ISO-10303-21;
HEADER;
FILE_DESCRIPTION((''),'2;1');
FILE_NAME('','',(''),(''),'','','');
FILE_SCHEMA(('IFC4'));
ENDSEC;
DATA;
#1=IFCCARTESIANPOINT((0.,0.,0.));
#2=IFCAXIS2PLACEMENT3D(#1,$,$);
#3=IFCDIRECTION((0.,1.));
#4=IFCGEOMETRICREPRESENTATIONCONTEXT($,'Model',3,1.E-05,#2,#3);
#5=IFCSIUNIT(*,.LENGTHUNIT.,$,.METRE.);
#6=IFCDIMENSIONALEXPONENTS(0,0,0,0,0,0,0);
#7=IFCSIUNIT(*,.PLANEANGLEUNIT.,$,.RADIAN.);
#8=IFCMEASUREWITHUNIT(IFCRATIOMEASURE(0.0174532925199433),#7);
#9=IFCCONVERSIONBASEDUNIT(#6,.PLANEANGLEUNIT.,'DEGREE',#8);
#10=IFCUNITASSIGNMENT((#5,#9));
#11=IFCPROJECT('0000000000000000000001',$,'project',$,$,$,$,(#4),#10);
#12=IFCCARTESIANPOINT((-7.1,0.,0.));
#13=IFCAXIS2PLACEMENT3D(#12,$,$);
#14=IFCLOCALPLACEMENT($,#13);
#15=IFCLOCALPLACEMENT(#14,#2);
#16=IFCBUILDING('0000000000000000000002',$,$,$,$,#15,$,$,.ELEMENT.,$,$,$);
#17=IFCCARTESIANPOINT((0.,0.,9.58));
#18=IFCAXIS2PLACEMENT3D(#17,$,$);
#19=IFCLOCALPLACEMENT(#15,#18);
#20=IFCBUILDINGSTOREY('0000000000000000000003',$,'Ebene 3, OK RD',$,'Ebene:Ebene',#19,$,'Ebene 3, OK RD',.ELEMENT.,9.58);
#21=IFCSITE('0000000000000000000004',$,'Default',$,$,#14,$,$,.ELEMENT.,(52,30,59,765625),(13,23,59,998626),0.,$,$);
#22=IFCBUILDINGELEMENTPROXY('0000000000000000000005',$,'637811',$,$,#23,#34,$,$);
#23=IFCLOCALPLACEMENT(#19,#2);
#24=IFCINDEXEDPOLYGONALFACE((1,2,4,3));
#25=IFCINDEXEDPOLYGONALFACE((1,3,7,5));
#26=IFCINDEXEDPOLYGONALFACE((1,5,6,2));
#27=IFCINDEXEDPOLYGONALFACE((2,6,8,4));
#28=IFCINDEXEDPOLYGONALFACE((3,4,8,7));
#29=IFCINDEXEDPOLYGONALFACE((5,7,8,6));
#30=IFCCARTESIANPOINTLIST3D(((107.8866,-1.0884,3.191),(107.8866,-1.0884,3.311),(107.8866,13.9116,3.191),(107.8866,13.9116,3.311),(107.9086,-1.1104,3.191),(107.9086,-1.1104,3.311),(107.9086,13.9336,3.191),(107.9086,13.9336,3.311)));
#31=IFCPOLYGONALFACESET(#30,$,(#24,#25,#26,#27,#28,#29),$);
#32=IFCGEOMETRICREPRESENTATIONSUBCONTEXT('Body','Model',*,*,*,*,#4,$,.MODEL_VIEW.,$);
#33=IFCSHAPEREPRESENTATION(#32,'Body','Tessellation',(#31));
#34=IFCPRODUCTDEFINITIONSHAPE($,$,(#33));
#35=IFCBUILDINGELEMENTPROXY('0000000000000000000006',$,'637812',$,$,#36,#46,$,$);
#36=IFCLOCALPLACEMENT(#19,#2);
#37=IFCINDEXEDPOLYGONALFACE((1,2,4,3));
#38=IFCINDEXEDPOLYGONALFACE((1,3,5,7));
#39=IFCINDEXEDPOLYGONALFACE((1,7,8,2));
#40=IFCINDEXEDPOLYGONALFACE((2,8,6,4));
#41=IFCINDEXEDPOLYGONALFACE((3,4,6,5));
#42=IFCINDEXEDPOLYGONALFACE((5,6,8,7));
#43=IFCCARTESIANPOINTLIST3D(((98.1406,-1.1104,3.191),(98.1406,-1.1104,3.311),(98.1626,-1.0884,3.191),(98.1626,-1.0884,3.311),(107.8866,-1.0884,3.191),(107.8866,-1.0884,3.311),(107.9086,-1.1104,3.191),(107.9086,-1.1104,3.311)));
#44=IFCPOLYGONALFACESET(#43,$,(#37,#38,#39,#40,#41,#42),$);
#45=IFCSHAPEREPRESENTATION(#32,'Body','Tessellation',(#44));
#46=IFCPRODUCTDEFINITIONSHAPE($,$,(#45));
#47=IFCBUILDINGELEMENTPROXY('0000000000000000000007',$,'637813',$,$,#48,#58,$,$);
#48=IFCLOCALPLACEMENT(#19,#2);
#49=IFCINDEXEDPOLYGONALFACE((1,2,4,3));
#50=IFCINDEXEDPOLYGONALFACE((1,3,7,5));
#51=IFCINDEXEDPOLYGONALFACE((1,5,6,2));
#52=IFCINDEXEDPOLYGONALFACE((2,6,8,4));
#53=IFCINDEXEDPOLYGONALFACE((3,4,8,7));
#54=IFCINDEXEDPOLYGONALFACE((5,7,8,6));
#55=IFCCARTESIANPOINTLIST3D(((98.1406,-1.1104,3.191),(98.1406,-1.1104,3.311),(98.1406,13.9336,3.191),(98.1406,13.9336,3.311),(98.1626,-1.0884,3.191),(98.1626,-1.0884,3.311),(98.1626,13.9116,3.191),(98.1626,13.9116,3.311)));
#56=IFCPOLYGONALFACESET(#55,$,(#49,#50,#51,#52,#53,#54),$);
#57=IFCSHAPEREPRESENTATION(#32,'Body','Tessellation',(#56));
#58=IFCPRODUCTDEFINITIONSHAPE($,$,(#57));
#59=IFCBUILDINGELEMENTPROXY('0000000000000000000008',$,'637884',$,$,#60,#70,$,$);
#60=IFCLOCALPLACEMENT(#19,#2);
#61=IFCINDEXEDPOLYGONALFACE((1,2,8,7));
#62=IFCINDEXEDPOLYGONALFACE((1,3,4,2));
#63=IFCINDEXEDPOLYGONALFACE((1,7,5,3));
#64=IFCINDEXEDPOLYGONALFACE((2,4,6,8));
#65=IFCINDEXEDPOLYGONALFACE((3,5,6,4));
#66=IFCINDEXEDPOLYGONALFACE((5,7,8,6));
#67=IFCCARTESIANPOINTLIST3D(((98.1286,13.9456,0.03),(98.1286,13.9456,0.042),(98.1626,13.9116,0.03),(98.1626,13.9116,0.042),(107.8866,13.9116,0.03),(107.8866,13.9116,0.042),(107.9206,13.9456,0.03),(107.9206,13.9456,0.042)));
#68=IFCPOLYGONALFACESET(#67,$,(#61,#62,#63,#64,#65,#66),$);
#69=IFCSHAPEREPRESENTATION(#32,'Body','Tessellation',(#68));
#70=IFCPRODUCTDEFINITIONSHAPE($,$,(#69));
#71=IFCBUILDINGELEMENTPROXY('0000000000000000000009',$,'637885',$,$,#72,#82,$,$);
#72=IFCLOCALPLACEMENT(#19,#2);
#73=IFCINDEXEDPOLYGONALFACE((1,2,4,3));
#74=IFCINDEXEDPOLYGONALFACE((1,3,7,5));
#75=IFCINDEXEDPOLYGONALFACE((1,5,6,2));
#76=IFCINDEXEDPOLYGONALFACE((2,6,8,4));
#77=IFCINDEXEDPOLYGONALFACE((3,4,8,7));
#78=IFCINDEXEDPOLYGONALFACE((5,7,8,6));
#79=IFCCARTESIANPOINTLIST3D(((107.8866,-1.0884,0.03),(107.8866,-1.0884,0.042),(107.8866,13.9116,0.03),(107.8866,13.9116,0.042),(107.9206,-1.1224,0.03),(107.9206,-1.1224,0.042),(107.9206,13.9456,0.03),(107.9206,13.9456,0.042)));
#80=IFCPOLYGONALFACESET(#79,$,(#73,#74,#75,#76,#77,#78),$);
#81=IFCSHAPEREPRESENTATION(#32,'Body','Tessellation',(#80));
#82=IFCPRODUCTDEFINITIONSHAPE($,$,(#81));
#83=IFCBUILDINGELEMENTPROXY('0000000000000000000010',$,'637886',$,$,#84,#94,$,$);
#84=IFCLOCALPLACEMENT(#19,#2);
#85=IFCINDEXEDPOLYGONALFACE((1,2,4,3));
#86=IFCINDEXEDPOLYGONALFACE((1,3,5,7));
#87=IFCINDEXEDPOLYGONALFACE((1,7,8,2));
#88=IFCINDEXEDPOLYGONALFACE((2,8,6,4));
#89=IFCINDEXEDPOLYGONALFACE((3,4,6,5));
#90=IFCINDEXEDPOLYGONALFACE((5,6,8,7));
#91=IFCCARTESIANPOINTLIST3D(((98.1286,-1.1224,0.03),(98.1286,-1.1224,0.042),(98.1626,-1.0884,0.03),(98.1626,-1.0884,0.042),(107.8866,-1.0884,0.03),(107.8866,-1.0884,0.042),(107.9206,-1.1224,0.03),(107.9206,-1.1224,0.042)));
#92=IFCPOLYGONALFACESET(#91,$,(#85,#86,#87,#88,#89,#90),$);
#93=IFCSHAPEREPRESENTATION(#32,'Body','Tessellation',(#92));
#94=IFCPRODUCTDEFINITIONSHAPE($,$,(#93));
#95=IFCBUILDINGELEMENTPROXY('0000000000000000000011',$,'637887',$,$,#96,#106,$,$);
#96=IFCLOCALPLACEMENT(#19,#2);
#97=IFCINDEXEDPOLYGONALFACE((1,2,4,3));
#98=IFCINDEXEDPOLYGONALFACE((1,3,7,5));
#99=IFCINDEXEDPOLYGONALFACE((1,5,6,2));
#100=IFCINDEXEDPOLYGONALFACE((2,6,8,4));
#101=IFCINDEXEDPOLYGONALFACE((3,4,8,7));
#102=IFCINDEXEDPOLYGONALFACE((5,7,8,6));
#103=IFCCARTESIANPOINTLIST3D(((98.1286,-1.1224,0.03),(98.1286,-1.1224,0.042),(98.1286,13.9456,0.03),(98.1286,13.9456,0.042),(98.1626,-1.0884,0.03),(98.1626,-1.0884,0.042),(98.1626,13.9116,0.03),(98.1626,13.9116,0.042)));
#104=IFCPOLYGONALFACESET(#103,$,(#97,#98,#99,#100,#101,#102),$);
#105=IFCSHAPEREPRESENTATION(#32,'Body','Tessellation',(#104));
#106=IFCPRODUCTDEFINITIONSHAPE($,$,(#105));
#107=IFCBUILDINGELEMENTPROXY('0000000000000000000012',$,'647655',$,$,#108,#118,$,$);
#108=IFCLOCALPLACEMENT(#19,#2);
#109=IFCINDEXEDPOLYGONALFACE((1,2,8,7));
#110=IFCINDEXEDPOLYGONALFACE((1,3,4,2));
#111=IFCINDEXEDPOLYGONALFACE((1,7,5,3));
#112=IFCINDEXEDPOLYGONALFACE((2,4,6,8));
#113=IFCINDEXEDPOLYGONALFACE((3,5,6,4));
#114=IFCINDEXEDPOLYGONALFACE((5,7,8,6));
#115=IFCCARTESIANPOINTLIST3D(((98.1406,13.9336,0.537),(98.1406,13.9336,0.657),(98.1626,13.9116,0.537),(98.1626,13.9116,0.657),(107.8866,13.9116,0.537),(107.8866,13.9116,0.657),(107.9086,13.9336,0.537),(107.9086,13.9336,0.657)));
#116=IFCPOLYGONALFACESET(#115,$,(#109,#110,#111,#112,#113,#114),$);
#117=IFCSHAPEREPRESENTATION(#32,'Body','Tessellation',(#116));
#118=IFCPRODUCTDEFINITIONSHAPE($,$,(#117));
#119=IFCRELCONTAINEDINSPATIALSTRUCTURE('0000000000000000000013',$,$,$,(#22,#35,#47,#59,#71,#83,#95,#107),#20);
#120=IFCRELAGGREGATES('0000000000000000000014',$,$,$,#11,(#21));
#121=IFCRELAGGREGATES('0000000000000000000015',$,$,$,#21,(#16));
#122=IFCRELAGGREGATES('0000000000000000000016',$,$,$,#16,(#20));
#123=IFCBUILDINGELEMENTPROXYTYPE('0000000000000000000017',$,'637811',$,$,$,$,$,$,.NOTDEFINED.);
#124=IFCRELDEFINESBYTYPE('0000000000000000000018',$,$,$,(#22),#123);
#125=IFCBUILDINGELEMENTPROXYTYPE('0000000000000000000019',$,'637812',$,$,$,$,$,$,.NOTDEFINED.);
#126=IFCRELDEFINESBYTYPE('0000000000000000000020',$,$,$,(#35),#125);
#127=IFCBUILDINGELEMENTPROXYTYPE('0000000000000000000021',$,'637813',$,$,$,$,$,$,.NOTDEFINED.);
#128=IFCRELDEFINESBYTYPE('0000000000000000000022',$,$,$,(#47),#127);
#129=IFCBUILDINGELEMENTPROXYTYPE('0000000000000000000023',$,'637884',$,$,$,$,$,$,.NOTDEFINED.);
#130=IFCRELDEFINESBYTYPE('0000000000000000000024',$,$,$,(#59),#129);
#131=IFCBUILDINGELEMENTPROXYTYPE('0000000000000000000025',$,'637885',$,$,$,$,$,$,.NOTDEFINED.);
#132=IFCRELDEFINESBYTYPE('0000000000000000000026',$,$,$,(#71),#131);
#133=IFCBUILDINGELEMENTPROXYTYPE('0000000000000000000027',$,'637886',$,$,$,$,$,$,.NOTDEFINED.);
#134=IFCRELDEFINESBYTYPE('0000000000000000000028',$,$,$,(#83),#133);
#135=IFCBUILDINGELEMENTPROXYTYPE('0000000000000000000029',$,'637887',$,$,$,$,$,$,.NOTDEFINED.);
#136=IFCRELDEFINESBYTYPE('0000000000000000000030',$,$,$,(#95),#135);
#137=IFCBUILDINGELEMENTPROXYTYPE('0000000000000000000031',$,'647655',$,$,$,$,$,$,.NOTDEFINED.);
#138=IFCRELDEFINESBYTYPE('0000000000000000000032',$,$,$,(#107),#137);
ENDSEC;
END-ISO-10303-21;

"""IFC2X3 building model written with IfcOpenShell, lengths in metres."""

from ifc_helpers import new_model, entity, si_unit, converted_unit, direction, frame, origin, place, context, subcontext, project, spatial, polyline, outline, extrude, type_object, element, save


model = new_model("IFC2X3")

# Units and contexts
model_context = context("Model", 3, precision=1e-05, world=origin(), true_north=direction((0.0, 1.0)))
body_context = subcontext(model_context, "Body", "Model", "MODEL_VIEW")
ifc_project = project(units=[si_unit("LENGTHUNIT", "METRE"), converted_unit("PLANEANGLEUNIT", "DEGREE", entity("IfcRatioMeasure", 0.0174532925199433), si_unit("PLANEANGLEUNIT", "RADIAN"), dimensions=[0, 0, 0, 0, 0, 0, 0])], contexts=[model_context])

# Site, building, storey
site_placement = place(None, frame((-7.1, 0.0, 0.0)))
site = spatial("IfcSite", under=ifc_project, at=site_placement, Name="Default", CompositionType="ELEMENT", RefLatitude=(52, 30, 59, 765625), RefLongitude=(13, 23, 59, 998626), RefElevation=0.0)
building_placement = place(site_placement, origin())
building = spatial("IfcBuilding", under=site, at=building_placement, CompositionType="ELEMENT")
storey_placement = place(building_placement, frame((0.0, 0.0, 9.58)))
storey = spatial("IfcBuildingStorey", under=building, at=storey_placement, Name="Ebene 3, OK RD", ObjectType="Ebene:Ebene", LongName="Ebene 3, OK RD", CompositionType="ELEMENT", Elevation=9.58)

# Building element proxies
building_element_proxy_type_1 = type_object("IfcBuildingElementProxyType", Name="637811", PredefinedType="NOTDEFINED")
proxy_1_placement = place(storey_placement, origin())
element("IfcBuildingElementProxy", 1, at=proxy_1_placement, inside=storey, type_object=building_element_proxy_type_1, Name="637811", context=body_context, shape_type="SweptSolid", body=[
    extrude(outline(polyline([(-7.5, -0.011), (7.5, -0.011), (7.522, 0.011), (-7.522, 0.011), (-7.5, -0.011)])), frame((107.8976, 6.4116, 3.191), z_axis=(0.0, 0.0, 1.0), x_axis=(0.0, -1.0, 0.0)), (0.0, 0.0, 1.0), 0.12),
])
building_element_proxy_type_2 = type_object("IfcBuildingElementProxyType", Name="637812", PredefinedType="NOTDEFINED")
proxy_2_placement = place(storey_placement, origin())
element("IfcBuildingElementProxy", 2, at=proxy_2_placement, inside=storey, type_object=building_element_proxy_type_2, Name="637812", context=body_context, shape_type="SweptSolid", body=[
    extrude(outline(polyline([(-4.862, -0.011), (4.862, -0.011), (4.884, 0.011), (-4.884, 0.011), (-4.862, -0.011)])), frame((103.0246, -1.0994, 3.191), z_axis=(0.0, 0.0, 1.0), x_axis=(-1.0, 0.0, 0.0)), (0.0, 0.0, 1.0), 0.12),
])
building_element_proxy_type_3 = type_object("IfcBuildingElementProxyType", Name="637813", PredefinedType="NOTDEFINED")
proxy_3_placement = place(storey_placement, origin())
element("IfcBuildingElementProxy", 3, at=proxy_3_placement, inside=storey, type_object=building_element_proxy_type_3, Name="637813", context=body_context, shape_type="SweptSolid", body=[
    extrude(outline(polyline([(-7.5, -0.011), (7.5, -0.011), (7.522, 0.011), (-7.522, 0.011), (-7.5, -0.011)])), frame((98.1516, 6.4116, 3.191), z_axis=(0.0, 0.0, 1.0), x_axis=(0.0, 1.0, 0.0)), (0.0, 0.0, 1.0), 0.12),
])
building_element_proxy_type_4 = type_object("IfcBuildingElementProxyType", Name="637884", PredefinedType="NOTDEFINED")
proxy_4_placement = place(storey_placement, origin())
element("IfcBuildingElementProxy", 4, at=proxy_4_placement, inside=storey, type_object=building_element_proxy_type_4, Name="637884", context=body_context, shape_type="SweptSolid", body=[
    extrude(outline(polyline([(-4.862, -0.017), (4.862, -0.017), (4.896, 0.017), (-4.896, 0.017), (-4.862, -0.017)])), frame((103.0246, 13.9286, 0.03)), (0.0, 0.0, 1.0), 0.012),
])
building_element_proxy_type_5 = type_object("IfcBuildingElementProxyType", Name="637885", PredefinedType="NOTDEFINED")
proxy_5_placement = place(storey_placement, origin())
element("IfcBuildingElementProxy", 5, at=proxy_5_placement, inside=storey, type_object=building_element_proxy_type_5, Name="637885", context=body_context, shape_type="SweptSolid", body=[
    extrude(outline(polyline([(-7.5, -0.017), (7.5, -0.017), (7.534, 0.017), (-7.534, 0.017), (-7.5, -0.017)])), frame((107.9036, 6.4116, 0.03), z_axis=(0.0, 0.0, 1.0), x_axis=(0.0, -1.0, 0.0)), (0.0, 0.0, 1.0), 0.012),
])
building_element_proxy_type_6 = type_object("IfcBuildingElementProxyType", Name="637886", PredefinedType="NOTDEFINED")
proxy_6_placement = place(storey_placement, origin())
element("IfcBuildingElementProxy", 6, at=proxy_6_placement, inside=storey, type_object=building_element_proxy_type_6, Name="637886", context=body_context, shape_type="SweptSolid", body=[
    extrude(outline(polyline([(-4.862, -0.017), (4.862, -0.017), (4.896, 0.017), (-4.896, 0.017), (-4.862, -0.017)])), frame((103.0246, -1.1054, 0.03), z_axis=(0.0, 0.0, 1.0), x_axis=(-1.0, 0.0, 0.0)), (0.0, 0.0, 1.0), 0.012),
])
building_element_proxy_type_7 = type_object("IfcBuildingElementProxyType", Name="637887", PredefinedType="NOTDEFINED")
proxy_7_placement = place(storey_placement, origin())
element("IfcBuildingElementProxy", 7, at=proxy_7_placement, inside=storey, type_object=building_element_proxy_type_7, Name="637887", context=body_context, shape_type="SweptSolid", body=[
    extrude(outline(polyline([(-7.5, -0.017), (7.5, -0.017), (7.534, 0.017), (-7.534, 0.017), (-7.5, -0.017)])), frame((98.1456, 6.4116, 0.03), z_axis=(0.0, 0.0, 1.0), x_axis=(0.0, 1.0, 0.0)), (0.0, 0.0, 1.0), 0.012),
])
building_element_proxy_type_8 = type_object("IfcBuildingElementProxyType", Name="647655", PredefinedType="NOTDEFINED")
proxy_8_placement = place(storey_placement, origin())
element("IfcBuildingElementProxy", 8, at=proxy_8_placement, inside=storey, type_object=building_element_proxy_type_8, Name="647655", context=body_context, shape_type="SweptSolid", body=[
    extrude(outline(polyline([(-4.862, -0.011), (4.862, -0.011), (4.884, 0.011), (-4.884, 0.011), (-4.862, -0.011)])), frame((103.0246, 13.9226, 0.537)), (0.0, 0.0, 1.0), 0.12),
])

save(model, "model.ifc")
